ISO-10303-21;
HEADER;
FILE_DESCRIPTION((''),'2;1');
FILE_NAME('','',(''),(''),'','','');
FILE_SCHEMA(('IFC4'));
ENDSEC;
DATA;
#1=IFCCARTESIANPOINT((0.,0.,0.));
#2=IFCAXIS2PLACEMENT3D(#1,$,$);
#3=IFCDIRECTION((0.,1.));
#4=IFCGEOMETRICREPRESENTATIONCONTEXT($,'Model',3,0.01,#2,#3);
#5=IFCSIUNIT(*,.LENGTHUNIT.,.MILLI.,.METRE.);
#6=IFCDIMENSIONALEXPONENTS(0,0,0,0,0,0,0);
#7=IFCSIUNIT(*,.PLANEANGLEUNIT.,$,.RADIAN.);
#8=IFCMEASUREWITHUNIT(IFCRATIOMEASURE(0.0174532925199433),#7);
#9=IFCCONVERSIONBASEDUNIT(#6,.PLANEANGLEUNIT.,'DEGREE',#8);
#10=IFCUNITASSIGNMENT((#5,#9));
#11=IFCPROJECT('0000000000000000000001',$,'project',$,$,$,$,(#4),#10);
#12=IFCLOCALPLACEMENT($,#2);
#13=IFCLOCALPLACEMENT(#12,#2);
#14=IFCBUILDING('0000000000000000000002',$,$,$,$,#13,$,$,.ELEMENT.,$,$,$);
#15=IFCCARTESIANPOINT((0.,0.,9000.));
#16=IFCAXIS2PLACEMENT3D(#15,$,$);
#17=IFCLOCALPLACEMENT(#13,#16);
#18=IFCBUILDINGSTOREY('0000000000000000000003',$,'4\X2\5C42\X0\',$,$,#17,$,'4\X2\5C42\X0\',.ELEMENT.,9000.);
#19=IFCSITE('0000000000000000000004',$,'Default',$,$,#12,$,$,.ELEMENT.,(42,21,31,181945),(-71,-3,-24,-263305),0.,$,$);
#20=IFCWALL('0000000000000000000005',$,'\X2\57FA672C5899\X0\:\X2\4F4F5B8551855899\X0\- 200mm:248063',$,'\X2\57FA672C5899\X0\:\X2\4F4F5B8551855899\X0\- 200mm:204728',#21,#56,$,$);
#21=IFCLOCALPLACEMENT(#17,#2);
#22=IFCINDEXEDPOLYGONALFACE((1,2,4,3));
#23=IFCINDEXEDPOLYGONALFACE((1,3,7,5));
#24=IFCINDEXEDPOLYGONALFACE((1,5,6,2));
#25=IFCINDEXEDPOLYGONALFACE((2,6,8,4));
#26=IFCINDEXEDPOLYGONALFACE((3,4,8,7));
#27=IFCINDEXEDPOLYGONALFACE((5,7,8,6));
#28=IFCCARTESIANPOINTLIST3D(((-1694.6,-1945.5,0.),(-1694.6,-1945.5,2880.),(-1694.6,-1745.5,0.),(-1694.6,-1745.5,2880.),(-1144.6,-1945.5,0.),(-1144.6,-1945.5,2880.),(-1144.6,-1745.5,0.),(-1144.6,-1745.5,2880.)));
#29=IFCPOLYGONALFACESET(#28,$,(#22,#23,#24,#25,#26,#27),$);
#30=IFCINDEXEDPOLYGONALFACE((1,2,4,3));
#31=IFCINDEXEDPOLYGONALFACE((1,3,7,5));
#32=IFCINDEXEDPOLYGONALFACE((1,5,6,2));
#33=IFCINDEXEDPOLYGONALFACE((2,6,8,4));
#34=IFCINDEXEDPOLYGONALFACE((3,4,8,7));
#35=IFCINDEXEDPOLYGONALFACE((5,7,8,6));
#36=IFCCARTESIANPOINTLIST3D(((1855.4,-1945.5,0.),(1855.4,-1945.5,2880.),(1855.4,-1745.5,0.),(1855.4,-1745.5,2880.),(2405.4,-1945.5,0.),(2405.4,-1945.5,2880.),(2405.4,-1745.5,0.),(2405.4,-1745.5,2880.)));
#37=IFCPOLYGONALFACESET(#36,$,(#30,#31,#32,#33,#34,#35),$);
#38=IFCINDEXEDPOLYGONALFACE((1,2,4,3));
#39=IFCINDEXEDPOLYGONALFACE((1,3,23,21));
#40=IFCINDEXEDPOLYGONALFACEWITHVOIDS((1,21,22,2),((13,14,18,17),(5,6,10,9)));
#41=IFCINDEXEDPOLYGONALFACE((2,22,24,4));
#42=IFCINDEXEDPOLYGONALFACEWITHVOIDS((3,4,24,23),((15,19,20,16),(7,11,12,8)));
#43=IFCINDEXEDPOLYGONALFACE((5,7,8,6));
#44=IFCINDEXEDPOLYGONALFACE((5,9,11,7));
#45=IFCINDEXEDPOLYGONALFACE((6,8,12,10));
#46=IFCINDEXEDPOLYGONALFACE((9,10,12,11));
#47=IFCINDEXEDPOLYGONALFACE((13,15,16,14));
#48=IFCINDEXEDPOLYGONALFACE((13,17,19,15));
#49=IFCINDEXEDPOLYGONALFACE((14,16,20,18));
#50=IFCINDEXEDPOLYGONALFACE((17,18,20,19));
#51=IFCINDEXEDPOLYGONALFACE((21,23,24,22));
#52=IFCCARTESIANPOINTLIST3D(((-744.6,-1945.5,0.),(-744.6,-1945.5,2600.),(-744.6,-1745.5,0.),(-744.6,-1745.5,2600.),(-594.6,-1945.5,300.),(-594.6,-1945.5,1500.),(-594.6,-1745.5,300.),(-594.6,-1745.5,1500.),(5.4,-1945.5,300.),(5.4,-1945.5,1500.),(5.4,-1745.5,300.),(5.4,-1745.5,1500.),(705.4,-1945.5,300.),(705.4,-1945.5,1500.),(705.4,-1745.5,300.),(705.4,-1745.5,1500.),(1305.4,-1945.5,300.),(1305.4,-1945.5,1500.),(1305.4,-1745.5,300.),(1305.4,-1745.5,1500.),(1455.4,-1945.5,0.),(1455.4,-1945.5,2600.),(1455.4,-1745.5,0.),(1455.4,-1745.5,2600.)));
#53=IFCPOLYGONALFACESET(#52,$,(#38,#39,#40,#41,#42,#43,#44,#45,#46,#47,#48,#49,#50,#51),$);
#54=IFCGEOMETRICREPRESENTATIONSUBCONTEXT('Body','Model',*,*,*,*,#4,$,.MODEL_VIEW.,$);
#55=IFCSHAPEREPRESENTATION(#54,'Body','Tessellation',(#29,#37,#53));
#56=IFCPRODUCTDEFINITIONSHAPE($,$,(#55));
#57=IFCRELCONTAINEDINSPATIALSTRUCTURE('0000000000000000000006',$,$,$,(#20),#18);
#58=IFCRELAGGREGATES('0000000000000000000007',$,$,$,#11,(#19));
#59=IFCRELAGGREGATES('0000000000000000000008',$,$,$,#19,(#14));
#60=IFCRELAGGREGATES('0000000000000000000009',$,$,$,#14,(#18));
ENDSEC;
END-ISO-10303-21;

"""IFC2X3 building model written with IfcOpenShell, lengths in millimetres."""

from ifc_helpers import new_model, entity, si_unit, converted_unit, direction, frame, frame_2d, origin, origin_2d_with_axis, place, context, subcontext, project, spatial, rectangle, extrude, element, save


model = new_model("IFC2X3")

# Units and contexts
model_context = context("Model", 3, precision=0.01, world=origin(), true_north=direction((0.0, 1.0)))
body_context = subcontext(model_context, "Body", "Model", "MODEL_VIEW")
ifc_project = project(units=[si_unit("LENGTHUNIT", "METRE", prefix="MILLI"), converted_unit("PLANEANGLEUNIT", "DEGREE", entity("IfcRatioMeasure", 0.0174532925199433), si_unit("PLANEANGLEUNIT", "RADIAN"), dimensions=[0, 0, 0, 0, 0, 0, 0])], contexts=[model_context])

# Site, building, storey
site_placement = place(None, origin())
site = spatial("IfcSite", under=ifc_project, at=site_placement, Name="Default", CompositionType="ELEMENT", RefLatitude=(42, 21, 31, 181945), RefLongitude=(-71, -3, -24, -263305), RefElevation=0.0)
building_placement = place(site_placement, origin())
building = spatial("IfcBuilding", under=site, at=building_placement, CompositionType="ELEMENT")
storey_placement = place(building_placement, frame((0.0, 0.0, 9000.0)))
storey = spatial("IfcBuildingStorey", under=building, at=storey_placement, Name="4层", LongName="4层", CompositionType="ELEMENT", Elevation=9000.0)

# Wall, openings
wall_1_placement = place(storey_placement, frame((-1694.6, -1845.5, 0.0)))
wall_1 = element("IfcWall", 1, at=wall_1_placement, inside=storey, Name="基本墙:住宅内墙- 200mm:248063", ObjectType="基本墙:住宅内墙- 200mm:204728", context=body_context, shape_type="SweptSolid", body=[
    extrude(rectangle(XDim=550.0, YDim=200.0, at=frame_2d((0.0, 0.0), x_axis=(1.0, 0.0))), frame((275.0, 0.0, 0.0)), (0.0, 0.0, 1.0), 2880.0),
    extrude(rectangle(XDim=550.0, YDim=200.0, at=frame_2d((0.0, 0.0), x_axis=(1.0, 0.0))), frame((3825.0, 0.0, 0.0), z_axis=(0.0, 0.0, 1.0), x_axis=(-1.0, 0.0, 0.0)), (0.0, 0.0, 1.0), 2880.0),
    extrude(rectangle(XDim=2200.0, YDim=200.0, at=frame_2d((0.0, -33.3), x_axis=(1.0, 0.0))), frame((2050.0, -33.3, 0.0), z_axis=(0.0, 0.0, 1.0), x_axis=(-1.0, 0.0, 0.0)), (0.0, 0.0, 1.0), 2600.0),
])
opening_1_placement = place(storey_placement, frame((-1694.6, -1845.5, 0.0)))
element("IfcOpeningElement", 2, at=opening_1_placement, cuts=wall_1, ObjectType="Opening", context=body_context, shape_type="SweptSolid", body=[
    extrude(rectangle(XDim=1200.0, YDim=600.0, at=frame_2d((0.0, 0.0), x_axis=(1.0, 0.0))), frame((2700.0, -100.0, 900.0), z_axis=(0.0, 1.0, 0.0), x_axis=(0.0, 0.0, 1.0)), (0.0, 0.0, 1.0), 200.0),
])
opening_2_placement = place(storey_placement, frame((-1694.6, -1845.5, 0.0)))
element("IfcOpeningElement", 3, at=opening_2_placement, cuts=wall_1, ObjectType="Opening", context=body_context, shape_type="SweptSolid", body=[
    extrude(rectangle(XDim=1200.0, YDim=600.0, at=origin_2d_with_axis()), frame((1400.0, -100.0, 900.0), z_axis=(0.0, 1.0, 0.0), x_axis=(0.0, 0.0, 1.0)), (0.0, 0.0, 1.0), 200.0),
])
opening_3_placement = place(wall_1_placement, frame((1700.0, 100.0, 300.0)))
element("IfcOpeningElement", 4, at=opening_3_placement, cuts=wall_1, ObjectType="Opening", context=body_context, shape_type="SweptSolid", body=[
    extrude(rectangle(XDim=1200.0, YDim=600.0, at=frame_2d((600.0, 300.0), x_axis=(-1.0, 0.0))), frame((0.0, 0.0, 0.0), z_axis=(0.0, -1.0, 0.0), x_axis=(0.0, 0.0, 1.0)), (0.0, 0.0, 1.0), 200.0),
])
opening_4_placement = place(wall_1_placement, frame((3000.0, 100.0, 300.0)))
element("IfcOpeningElement", 5, at=opening_4_placement, cuts=wall_1, ObjectType="Opening", context=body_context, shape_type="SweptSolid", body=[
    extrude(rectangle(XDim=1200.0, YDim=600.0, at=frame_2d((600.0, 300.0), x_axis=(-1.0, 0.0))), frame((0.0, 0.0, 0.0), z_axis=(0.0, -1.0, 0.0), x_axis=(0.0, 0.0, 1.0)), (0.0, 0.0, 1.0), 200.0),
])

save(model, "model.ifc")
